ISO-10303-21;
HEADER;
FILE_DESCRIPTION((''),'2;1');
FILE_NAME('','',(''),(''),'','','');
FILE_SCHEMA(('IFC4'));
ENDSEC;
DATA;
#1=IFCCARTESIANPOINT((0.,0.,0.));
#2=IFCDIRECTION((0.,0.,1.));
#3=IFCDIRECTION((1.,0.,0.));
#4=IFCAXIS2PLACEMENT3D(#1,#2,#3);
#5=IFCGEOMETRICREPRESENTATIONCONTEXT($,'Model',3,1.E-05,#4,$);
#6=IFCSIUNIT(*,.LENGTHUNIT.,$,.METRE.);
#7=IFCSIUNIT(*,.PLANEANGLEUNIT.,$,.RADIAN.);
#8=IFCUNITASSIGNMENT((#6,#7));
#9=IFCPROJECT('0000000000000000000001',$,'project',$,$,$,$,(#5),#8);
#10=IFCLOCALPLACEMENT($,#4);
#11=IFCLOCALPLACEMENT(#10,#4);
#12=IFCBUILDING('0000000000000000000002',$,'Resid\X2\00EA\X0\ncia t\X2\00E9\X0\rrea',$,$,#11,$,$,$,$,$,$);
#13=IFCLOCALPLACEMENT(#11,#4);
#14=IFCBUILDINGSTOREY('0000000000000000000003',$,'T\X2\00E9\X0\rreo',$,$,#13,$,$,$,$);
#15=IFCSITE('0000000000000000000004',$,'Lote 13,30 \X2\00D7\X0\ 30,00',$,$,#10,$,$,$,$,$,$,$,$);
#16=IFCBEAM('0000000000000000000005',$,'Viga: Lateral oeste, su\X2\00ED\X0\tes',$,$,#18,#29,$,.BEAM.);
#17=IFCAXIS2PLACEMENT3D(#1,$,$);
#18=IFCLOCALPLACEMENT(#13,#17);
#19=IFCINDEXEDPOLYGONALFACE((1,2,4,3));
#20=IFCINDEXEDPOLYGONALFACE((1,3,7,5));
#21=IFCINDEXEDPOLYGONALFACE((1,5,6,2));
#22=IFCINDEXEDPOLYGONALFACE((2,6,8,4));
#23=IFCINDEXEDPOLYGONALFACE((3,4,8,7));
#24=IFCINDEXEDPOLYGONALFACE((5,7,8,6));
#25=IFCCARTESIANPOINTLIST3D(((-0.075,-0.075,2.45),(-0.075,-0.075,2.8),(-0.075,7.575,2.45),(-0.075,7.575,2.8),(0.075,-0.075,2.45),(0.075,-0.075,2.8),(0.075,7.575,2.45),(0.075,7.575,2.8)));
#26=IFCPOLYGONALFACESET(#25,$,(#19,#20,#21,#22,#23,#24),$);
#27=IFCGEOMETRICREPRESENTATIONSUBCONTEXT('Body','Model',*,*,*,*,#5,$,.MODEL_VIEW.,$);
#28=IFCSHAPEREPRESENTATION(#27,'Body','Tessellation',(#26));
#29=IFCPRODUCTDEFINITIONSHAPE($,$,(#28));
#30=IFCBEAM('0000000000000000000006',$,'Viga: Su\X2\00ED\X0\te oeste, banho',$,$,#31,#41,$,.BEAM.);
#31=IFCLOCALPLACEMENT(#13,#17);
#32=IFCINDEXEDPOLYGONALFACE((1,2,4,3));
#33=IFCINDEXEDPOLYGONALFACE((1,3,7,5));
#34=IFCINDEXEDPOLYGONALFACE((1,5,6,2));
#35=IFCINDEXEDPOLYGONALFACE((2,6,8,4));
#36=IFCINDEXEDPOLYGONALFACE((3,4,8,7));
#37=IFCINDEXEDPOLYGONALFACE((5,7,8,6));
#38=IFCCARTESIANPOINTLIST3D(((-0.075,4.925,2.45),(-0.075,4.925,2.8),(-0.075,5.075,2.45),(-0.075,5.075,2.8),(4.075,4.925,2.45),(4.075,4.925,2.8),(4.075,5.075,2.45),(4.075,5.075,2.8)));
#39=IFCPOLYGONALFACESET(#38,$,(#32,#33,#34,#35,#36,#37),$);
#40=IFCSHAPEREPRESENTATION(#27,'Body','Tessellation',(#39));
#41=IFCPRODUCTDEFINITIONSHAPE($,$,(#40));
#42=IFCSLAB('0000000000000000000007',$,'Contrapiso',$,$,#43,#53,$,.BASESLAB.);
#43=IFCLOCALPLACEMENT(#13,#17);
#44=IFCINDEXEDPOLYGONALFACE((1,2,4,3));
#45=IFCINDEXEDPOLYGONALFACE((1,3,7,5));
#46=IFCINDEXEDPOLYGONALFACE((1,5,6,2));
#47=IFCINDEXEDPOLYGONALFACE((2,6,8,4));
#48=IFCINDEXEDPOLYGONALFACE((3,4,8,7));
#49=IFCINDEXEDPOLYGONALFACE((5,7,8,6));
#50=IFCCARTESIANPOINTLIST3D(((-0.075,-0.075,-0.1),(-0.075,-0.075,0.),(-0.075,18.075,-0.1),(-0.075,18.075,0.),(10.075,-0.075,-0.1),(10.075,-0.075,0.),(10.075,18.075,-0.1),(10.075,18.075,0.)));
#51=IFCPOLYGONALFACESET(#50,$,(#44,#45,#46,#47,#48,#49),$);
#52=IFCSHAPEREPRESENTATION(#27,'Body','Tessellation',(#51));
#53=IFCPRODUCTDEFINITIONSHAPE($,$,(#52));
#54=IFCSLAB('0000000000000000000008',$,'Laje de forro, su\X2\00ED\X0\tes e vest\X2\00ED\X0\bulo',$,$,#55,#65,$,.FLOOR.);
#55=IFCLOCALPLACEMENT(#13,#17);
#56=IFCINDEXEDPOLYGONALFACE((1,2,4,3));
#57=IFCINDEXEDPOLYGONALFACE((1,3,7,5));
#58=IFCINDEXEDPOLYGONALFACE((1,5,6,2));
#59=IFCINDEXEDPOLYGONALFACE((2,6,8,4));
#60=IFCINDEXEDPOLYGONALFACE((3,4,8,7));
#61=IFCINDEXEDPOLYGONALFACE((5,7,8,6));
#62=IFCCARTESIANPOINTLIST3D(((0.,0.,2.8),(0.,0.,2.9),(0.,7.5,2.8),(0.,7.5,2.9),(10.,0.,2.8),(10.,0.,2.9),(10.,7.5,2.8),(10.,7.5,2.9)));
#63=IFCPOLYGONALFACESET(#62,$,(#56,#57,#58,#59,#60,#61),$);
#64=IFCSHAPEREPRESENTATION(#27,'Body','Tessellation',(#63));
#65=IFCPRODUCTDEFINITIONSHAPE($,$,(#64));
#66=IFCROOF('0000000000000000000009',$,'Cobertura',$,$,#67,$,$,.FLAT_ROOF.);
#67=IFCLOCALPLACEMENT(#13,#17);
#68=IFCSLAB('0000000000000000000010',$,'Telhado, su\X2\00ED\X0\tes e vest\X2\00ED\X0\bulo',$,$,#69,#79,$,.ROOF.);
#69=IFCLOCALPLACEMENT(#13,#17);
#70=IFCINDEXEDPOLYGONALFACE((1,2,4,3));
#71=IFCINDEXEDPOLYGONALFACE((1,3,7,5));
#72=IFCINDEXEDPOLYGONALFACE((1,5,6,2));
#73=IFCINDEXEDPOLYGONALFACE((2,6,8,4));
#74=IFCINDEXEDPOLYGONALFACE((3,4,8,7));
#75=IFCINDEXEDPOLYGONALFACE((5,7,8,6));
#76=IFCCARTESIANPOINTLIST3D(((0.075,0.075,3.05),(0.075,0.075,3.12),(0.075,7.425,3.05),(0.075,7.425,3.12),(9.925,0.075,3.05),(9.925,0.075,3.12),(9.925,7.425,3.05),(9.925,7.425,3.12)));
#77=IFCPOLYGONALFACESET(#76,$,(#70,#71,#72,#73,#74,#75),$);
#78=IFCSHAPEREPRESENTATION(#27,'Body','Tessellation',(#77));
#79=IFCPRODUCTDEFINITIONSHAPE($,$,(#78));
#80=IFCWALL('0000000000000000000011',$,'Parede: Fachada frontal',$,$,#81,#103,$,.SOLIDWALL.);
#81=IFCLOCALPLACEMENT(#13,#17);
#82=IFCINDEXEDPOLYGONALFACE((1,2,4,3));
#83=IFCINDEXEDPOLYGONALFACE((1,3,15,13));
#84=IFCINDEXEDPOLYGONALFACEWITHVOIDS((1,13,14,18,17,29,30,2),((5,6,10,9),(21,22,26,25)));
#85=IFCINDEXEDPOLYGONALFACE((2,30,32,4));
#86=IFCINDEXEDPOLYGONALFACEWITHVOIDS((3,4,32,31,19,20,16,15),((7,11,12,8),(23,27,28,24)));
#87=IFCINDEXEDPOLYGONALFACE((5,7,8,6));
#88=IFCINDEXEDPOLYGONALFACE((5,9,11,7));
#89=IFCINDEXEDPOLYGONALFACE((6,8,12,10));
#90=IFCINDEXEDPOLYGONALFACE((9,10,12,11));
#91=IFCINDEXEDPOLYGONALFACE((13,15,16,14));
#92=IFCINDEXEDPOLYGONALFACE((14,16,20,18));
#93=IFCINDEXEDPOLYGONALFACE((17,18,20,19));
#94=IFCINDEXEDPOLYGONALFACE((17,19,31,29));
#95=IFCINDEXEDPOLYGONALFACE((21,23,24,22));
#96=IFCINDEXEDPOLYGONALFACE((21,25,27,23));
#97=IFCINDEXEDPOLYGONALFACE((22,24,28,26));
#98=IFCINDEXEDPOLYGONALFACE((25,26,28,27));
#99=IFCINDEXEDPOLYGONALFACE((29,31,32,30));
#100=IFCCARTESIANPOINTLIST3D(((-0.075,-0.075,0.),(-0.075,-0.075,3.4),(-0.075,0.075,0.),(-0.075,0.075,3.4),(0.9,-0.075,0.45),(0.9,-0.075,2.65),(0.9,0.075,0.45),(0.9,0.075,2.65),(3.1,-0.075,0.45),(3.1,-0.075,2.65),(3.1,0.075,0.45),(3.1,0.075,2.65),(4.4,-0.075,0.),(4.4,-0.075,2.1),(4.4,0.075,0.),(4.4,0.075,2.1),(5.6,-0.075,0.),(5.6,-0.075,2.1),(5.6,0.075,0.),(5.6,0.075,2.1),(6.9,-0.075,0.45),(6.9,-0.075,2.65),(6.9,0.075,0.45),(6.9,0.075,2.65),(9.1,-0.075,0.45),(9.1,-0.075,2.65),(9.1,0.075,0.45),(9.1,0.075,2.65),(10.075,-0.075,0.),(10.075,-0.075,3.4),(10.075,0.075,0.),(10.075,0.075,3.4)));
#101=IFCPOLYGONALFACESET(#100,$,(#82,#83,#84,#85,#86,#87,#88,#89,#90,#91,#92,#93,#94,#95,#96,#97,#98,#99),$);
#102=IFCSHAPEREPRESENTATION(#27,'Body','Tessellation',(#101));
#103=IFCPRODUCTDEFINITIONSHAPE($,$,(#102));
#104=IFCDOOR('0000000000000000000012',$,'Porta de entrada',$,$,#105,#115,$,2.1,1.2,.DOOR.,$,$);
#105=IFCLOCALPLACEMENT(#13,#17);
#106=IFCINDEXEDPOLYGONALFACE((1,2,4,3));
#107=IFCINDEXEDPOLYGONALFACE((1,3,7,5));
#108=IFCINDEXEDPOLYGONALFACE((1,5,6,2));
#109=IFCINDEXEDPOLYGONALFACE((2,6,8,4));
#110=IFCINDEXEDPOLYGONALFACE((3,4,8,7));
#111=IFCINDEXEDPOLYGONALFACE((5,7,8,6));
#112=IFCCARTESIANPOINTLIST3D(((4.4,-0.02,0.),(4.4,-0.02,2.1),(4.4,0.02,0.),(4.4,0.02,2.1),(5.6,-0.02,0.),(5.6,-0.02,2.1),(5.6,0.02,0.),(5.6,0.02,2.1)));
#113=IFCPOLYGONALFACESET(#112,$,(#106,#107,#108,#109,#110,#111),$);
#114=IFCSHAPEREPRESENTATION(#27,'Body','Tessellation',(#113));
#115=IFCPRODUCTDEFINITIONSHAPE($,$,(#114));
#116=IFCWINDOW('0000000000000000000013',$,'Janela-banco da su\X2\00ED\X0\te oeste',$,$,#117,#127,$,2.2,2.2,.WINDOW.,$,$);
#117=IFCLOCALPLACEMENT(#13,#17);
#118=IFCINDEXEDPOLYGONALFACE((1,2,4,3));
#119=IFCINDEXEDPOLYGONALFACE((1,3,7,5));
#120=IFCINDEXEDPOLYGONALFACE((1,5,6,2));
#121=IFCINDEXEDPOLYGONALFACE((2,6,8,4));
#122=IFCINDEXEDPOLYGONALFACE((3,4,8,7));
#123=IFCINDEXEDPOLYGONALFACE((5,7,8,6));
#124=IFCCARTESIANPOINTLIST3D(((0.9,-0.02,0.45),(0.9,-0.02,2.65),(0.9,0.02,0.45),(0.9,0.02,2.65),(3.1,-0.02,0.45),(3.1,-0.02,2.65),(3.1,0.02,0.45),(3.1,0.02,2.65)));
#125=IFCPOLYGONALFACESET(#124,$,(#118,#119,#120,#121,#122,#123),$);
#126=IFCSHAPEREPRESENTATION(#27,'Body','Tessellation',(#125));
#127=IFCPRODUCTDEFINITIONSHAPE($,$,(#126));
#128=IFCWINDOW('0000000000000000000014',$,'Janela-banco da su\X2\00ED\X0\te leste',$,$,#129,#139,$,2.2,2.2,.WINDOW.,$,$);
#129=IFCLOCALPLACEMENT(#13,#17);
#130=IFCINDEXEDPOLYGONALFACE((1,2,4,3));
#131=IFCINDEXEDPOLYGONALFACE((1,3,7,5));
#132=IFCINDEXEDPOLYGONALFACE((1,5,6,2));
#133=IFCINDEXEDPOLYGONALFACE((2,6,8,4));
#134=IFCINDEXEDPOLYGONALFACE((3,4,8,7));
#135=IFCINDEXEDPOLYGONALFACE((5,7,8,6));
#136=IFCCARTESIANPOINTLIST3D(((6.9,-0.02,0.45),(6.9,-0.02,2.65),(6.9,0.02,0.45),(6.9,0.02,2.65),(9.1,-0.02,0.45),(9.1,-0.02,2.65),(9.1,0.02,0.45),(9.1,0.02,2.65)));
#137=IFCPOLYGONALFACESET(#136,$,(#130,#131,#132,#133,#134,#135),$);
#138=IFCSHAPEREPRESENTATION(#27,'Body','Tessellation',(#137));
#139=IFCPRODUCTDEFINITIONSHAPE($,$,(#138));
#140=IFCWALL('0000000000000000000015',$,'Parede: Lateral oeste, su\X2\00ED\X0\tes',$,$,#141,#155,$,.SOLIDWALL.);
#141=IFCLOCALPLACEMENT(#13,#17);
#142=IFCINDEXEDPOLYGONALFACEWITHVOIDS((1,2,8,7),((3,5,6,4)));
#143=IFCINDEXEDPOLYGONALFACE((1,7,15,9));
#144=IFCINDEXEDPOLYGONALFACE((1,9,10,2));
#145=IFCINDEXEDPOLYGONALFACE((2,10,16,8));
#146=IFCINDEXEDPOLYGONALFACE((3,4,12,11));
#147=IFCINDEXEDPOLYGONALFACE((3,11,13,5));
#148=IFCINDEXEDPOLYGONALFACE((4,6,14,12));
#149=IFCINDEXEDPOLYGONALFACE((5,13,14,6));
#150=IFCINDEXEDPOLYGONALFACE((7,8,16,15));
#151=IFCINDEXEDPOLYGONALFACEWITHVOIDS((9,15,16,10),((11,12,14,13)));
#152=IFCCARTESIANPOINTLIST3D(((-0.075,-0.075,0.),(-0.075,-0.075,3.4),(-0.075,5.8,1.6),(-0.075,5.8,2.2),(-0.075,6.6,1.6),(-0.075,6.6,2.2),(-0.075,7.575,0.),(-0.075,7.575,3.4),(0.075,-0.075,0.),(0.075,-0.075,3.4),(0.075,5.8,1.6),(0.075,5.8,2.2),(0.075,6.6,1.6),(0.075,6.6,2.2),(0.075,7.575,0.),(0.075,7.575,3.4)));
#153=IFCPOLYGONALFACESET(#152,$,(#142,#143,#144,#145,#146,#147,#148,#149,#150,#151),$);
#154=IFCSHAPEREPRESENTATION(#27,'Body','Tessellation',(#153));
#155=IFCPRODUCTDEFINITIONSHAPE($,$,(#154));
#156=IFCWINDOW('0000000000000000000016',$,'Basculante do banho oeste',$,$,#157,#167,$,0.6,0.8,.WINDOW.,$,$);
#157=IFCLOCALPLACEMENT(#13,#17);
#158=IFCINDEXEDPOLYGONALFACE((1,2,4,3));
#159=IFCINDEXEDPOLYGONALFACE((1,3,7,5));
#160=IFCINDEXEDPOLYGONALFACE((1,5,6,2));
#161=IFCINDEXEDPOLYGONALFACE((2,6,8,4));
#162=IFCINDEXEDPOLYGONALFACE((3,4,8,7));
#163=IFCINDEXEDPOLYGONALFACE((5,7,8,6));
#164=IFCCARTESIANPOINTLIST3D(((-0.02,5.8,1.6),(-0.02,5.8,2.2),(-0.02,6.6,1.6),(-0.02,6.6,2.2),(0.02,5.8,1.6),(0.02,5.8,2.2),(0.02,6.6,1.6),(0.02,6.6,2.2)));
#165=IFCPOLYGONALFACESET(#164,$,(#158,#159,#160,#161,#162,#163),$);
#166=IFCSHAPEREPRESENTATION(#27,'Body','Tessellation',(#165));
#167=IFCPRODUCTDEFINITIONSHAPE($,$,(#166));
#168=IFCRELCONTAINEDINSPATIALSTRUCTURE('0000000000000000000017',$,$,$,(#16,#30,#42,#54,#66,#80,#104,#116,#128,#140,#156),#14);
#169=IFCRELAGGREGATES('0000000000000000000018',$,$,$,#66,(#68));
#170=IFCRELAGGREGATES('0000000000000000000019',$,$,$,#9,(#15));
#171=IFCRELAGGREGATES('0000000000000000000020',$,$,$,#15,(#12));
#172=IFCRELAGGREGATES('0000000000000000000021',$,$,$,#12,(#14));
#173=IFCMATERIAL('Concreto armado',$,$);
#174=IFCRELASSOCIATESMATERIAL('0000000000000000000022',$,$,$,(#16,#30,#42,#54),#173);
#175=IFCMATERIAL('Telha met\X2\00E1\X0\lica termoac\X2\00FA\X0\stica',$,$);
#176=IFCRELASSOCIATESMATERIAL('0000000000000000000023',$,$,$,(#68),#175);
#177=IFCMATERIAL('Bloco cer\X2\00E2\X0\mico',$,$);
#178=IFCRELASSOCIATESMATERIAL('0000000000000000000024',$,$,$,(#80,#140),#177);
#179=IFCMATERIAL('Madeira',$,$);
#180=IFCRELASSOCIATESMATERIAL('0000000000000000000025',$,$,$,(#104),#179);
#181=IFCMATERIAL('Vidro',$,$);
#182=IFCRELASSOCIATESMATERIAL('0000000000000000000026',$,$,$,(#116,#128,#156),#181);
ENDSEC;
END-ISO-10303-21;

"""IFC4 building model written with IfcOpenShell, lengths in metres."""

from ifc_helpers import new_model, si_unit, frame, origin_with_axes, place, context, subcontext, project, spatial, line, indexed_curve, outline, extrude, material, element, fill, aggregate, save


model = new_model("IFC4")

# Units and contexts
model_context = context("Model", 3, precision=1e-05, world=origin_with_axes())
body_context = subcontext(model_context, "Body", "Model", "MODEL_VIEW")
ifc_project = project(units=[si_unit("LENGTHUNIT", "METRE"), si_unit("PLANEANGLEUNIT", "RADIAN")], contexts=[model_context])

# Site, building, storey
site_placement = place(None, origin_with_axes())
site = spatial("IfcSite", under=ifc_project, at=site_placement, Name="Lote 13,30 × 30,00")
building_placement = place(site_placement, origin_with_axes())
building = spatial("IfcBuilding", under=site, at=building_placement, Name="Residência térrea")
storey_placement = place(building_placement, origin_with_axes())
storey = spatial("IfcBuildingStorey", under=building, at=storey_placement, Name="Térreo")

# Shared definitions
ifc_material_1 = material(Name="Concreto armado")

# Beams
beam_1_placement = place(storey_placement, frame((-0.075, -0.075, 2.45), z_axis=(0.0, 0.0, 1.0), x_axis=(1.0, 0.0, 0.0)))
element("IfcBeam", 1, at=beam_1_placement, inside=storey, material=ifc_material_1, Name="Viga: Lateral oeste, suítes", PredefinedType="BEAM", context=body_context, shape_type="SweptSolid", body=[
    extrude(outline(indexed_curve([(0.0, 0.0), (0.15, 0.0), (0.15, 7.65), (0.0, 7.65)], segments=[line(1, 2, 3, 4, 1)])), origin_with_axes(), (0.0, 0.0, 1.0), 0.35),
])
beam_2_placement = place(storey_placement, frame((-0.075, 4.925, 2.45), z_axis=(0.0, 0.0, 1.0), x_axis=(1.0, 0.0, 0.0)))
element("IfcBeam", 2, at=beam_2_placement, inside=storey, material=ifc_material_1, Name="Viga: Suíte oeste, banho", PredefinedType="BEAM", context=body_context, shape_type="SweptSolid", body=[
    extrude(outline(indexed_curve([(0.0, 0.0), (4.15, 0.0), (4.15, 0.15), (0.0, 0.15)], segments=[line(1, 2, 3, 4, 1)])), origin_with_axes(), (0.0, 0.0, 1.0), 0.35),
])

# Slabs
slab_1_placement = place(storey_placement, frame((-0.075, -0.075, -0.1), z_axis=(0.0, 0.0, 1.0), x_axis=(1.0, 0.0, 0.0)))
element("IfcSlab", 3, at=slab_1_placement, inside=storey, material=ifc_material_1, Name="Contrapiso", PredefinedType="BASESLAB", context=body_context, shape_type="SweptSolid", body=[
    extrude(outline(indexed_curve([(0.0, 0.0), (10.15, 0.0), (10.15, 18.15), (0.0, 18.15)], segments=[line(1, 2, 3, 4, 1)])), origin_with_axes(), (0.0, 0.0, 1.0), 0.1),
])
slab_2_placement = place(storey_placement, frame((0.0, 0.0, 2.8), z_axis=(0.0, 0.0, 1.0), x_axis=(1.0, 0.0, 0.0)))
element("IfcSlab", 4, at=slab_2_placement, inside=storey, material=ifc_material_1, Name="Laje de forro, suítes e vestíbulo", PredefinedType="FLOOR", context=body_context, shape_type="SweptSolid", body=[
    extrude(outline(indexed_curve([(0.0, 0.0), (10.0, 0.0), (10.0, 7.5), (0.0, 7.5)], segments=[line(1, 2, 3, 4, 1)])), origin_with_axes(), (0.0, 0.0, 1.0), 0.1),
])

# Roof, slab
roof_placement = place(storey_placement, origin_with_axes())
roof = element("IfcRoof", 5, at=roof_placement, inside=storey, Name="Cobertura", PredefinedType="FLAT_ROOF")
ifc_material_2 = material(Name="Telha metálica termoacústica")
slab_3_placement = place(roof_placement, frame((0.075, 0.075, 3.05), z_axis=(0.0, 0.0, 1.0), x_axis=(1.0, 0.0, 0.0)))
slab_3 = element("IfcSlab", 6, at=slab_3_placement, material=ifc_material_2, Name="Telhado, suítes e vestíbulo", PredefinedType="ROOF", context=body_context, shape_type="SweptSolid", body=[
    extrude(outline(indexed_curve([(0.0, 0.0), (9.85, 0.0), (9.85, 7.35), (0.0, 7.35)], segments=[line(1, 2, 3, 4, 1)])), origin_with_axes(), (0.0, 0.0, 1.0), 0.07),
])
aggregate(roof, [slab_3])

# Wall, openings, door, windows
ifc_material_3 = material(Name="Bloco cerâmico")
wall_1_placement = place(storey_placement, frame((-0.075, -0.075, 0.0), z_axis=(0.0, 0.0, 1.0), x_axis=(1.0, 0.0, 0.0)))
wall_1 = element("IfcWall", 7, at=wall_1_placement, inside=storey, material=ifc_material_3, Name="Parede: Fachada frontal", PredefinedType="SOLIDWALL", context=body_context, shape_type="SweptSolid", body=[
    extrude(outline(indexed_curve([(0.0, 0.0), (10.15, 0.0), (10.15, 0.15), (0.0, 0.15)], segments=[line(1, 2, 3, 4, 1)])), origin_with_axes(), (0.0, 0.0, 1.0), 3.4),
])
opening_1_placement = place(wall_1_placement, frame((4.475, -0.05, 0.0), z_axis=(0.0, 0.0, 1.0), x_axis=(1.0, 0.0, 0.0)))
opening_1 = element("IfcOpeningElement", 8, at=opening_1_placement, cuts=wall_1, material=ifc_material_1, PredefinedType="OPENING", context=body_context, shape_type="SweptSolid", body=[
    extrude(outline(indexed_curve([(0.0, 0.0), (1.2, 0.0), (1.2, 0.25), (0.0, 0.25)], segments=[line(1, 2, 3, 4, 1)])), origin_with_axes(), (0.0, 0.0, 1.0), 2.1),
])
opening_2_placement = place(wall_1_placement, frame((0.975, -0.05, 0.45), z_axis=(0.0, 0.0, 1.0), x_axis=(1.0, 0.0, 0.0)))
opening_2 = element("IfcOpeningElement", 9, at=opening_2_placement, cuts=wall_1, material=ifc_material_1, PredefinedType="OPENING", context=body_context, shape_type="SweptSolid", body=[
    extrude(outline(indexed_curve([(0.0, 0.0), (2.2, 0.0), (2.2, 0.25), (0.0, 0.25)], segments=[line(1, 2, 3, 4, 1)])), origin_with_axes(), (0.0, 0.0, 1.0), 2.2),
])
opening_3_placement = place(wall_1_placement, frame((6.975, -0.05, 0.45), z_axis=(0.0, 0.0, 1.0), x_axis=(1.0, 0.0, 0.0)))
opening_3 = element("IfcOpeningElement", 10, at=opening_3_placement, cuts=wall_1, material=ifc_material_1, PredefinedType="OPENING", context=body_context, shape_type="SweptSolid", body=[
    extrude(outline(indexed_curve([(0.0, 0.0), (2.2, 0.0), (2.2, 0.25), (0.0, 0.25)], segments=[line(1, 2, 3, 4, 1)])), origin_with_axes(), (0.0, 0.0, 1.0), 2.2),
])
ifc_material_4 = material(Name="Madeira")
door_1_placement = place(storey_placement, frame((4.4, -0.02, 0.0), z_axis=(0.0, 0.0, 1.0), x_axis=(1.0, 0.0, 0.0)))
door_1 = element("IfcDoor", 11, at=door_1_placement, inside=storey, material=ifc_material_4, Name="Porta de entrada", OverallHeight=2.1, OverallWidth=1.2, PredefinedType="DOOR", context=body_context, shape_type="SweptSolid", body=[
    extrude(outline(indexed_curve([(0.0, 0.0), (1.2, 0.0), (1.2, 0.04), (0.0, 0.04)], segments=[line(1, 2, 3, 4, 1)])), origin_with_axes(), (0.0, 0.0, 1.0), 2.1),
])
fill(opening_1, door_1)
ifc_material_5 = material(Name="Vidro")
window_1_placement = place(storey_placement, frame((0.9, -0.02, 0.45), z_axis=(0.0, 0.0, 1.0), x_axis=(1.0, 0.0, 0.0)))
window_1 = element("IfcWindow", 12, at=window_1_placement, inside=storey, material=ifc_material_5, Name="Janela-banco da suíte oeste", OverallHeight=2.2, OverallWidth=2.2, PredefinedType="WINDOW", context=body_context, shape_type="SweptSolid", body=[
    extrude(outline(indexed_curve([(0.0, 0.0), (2.2, 0.0), (2.2, 0.04), (0.0, 0.04)], segments=[line(1, 2, 3, 4, 1)])), origin_with_axes(), (0.0, 0.0, 1.0), 2.2),
])
fill(opening_2, window_1)
window_2_placement = place(storey_placement, frame((6.9, -0.02, 0.45), z_axis=(0.0, 0.0, 1.0), x_axis=(1.0, 0.0, 0.0)))
window_2 = element("IfcWindow", 13, at=window_2_placement, inside=storey, material=ifc_material_5, Name="Janela-banco da suíte leste", OverallHeight=2.2, OverallWidth=2.2, PredefinedType="WINDOW", context=body_context, shape_type="SweptSolid", body=[
    extrude(outline(indexed_curve([(0.0, 0.0), (2.2, 0.0), (2.2, 0.04), (0.0, 0.04)], segments=[line(1, 2, 3, 4, 1)])), origin_with_axes(), (0.0, 0.0, 1.0), 2.2),
])
fill(opening_3, window_2)

# Wall, opening, window
wall_2_placement = place(storey_placement, frame((-0.075, -0.075, 0.0), z_axis=(0.0, 0.0, 1.0), x_axis=(1.0, 0.0, 0.0)))
wall_2 = element("IfcWall", 14, at=wall_2_placement, inside=storey, material=ifc_material_3, Name="Parede: Lateral oeste, suítes", PredefinedType="SOLIDWALL", context=body_context, shape_type="SweptSolid", body=[
    extrude(outline(indexed_curve([(0.0, 0.0), (0.15, 0.0), (0.15, 7.65), (0.0, 7.65)], segments=[line(1, 2, 3, 4, 1)])), origin_with_axes(), (0.0, 0.0, 1.0), 3.4),
])
opening_4_placement = place(wall_2_placement, frame((-0.05, 5.875, 1.6), z_axis=(0.0, 0.0, 1.0), x_axis=(1.0, 0.0, 0.0)))
opening_4 = element("IfcOpeningElement", 15, at=opening_4_placement, cuts=wall_2, material=ifc_material_1, PredefinedType="OPENING", context=body_context, shape_type="SweptSolid", body=[
    extrude(outline(indexed_curve([(0.0, 0.0), (0.25, 0.0), (0.25, 0.8), (0.0, 0.8)], segments=[line(1, 2, 3, 4, 1)])), origin_with_axes(), (0.0, 0.0, 1.0), 0.6),
])
window_3_placement = place(storey_placement, frame((-0.02, 5.8, 1.6), z_axis=(0.0, 0.0, 1.0), x_axis=(1.0, 0.0, 0.0)))
window_3 = element("IfcWindow", 16, at=window_3_placement, inside=storey, material=ifc_material_5, Name="Basculante do banho oeste", OverallHeight=0.6, OverallWidth=0.8, PredefinedType="WINDOW", context=body_context, shape_type="SweptSolid", body=[
    extrude(outline(indexed_curve([(0.0, 0.0), (0.04, 0.0), (0.04, 0.8), (0.0, 0.8)], segments=[line(1, 2, 3, 4, 1)])), origin_with_axes(), (0.0, 0.0, 1.0), 0.6),
])
fill(opening_4, window_3)

save(model, "model.ifc")
